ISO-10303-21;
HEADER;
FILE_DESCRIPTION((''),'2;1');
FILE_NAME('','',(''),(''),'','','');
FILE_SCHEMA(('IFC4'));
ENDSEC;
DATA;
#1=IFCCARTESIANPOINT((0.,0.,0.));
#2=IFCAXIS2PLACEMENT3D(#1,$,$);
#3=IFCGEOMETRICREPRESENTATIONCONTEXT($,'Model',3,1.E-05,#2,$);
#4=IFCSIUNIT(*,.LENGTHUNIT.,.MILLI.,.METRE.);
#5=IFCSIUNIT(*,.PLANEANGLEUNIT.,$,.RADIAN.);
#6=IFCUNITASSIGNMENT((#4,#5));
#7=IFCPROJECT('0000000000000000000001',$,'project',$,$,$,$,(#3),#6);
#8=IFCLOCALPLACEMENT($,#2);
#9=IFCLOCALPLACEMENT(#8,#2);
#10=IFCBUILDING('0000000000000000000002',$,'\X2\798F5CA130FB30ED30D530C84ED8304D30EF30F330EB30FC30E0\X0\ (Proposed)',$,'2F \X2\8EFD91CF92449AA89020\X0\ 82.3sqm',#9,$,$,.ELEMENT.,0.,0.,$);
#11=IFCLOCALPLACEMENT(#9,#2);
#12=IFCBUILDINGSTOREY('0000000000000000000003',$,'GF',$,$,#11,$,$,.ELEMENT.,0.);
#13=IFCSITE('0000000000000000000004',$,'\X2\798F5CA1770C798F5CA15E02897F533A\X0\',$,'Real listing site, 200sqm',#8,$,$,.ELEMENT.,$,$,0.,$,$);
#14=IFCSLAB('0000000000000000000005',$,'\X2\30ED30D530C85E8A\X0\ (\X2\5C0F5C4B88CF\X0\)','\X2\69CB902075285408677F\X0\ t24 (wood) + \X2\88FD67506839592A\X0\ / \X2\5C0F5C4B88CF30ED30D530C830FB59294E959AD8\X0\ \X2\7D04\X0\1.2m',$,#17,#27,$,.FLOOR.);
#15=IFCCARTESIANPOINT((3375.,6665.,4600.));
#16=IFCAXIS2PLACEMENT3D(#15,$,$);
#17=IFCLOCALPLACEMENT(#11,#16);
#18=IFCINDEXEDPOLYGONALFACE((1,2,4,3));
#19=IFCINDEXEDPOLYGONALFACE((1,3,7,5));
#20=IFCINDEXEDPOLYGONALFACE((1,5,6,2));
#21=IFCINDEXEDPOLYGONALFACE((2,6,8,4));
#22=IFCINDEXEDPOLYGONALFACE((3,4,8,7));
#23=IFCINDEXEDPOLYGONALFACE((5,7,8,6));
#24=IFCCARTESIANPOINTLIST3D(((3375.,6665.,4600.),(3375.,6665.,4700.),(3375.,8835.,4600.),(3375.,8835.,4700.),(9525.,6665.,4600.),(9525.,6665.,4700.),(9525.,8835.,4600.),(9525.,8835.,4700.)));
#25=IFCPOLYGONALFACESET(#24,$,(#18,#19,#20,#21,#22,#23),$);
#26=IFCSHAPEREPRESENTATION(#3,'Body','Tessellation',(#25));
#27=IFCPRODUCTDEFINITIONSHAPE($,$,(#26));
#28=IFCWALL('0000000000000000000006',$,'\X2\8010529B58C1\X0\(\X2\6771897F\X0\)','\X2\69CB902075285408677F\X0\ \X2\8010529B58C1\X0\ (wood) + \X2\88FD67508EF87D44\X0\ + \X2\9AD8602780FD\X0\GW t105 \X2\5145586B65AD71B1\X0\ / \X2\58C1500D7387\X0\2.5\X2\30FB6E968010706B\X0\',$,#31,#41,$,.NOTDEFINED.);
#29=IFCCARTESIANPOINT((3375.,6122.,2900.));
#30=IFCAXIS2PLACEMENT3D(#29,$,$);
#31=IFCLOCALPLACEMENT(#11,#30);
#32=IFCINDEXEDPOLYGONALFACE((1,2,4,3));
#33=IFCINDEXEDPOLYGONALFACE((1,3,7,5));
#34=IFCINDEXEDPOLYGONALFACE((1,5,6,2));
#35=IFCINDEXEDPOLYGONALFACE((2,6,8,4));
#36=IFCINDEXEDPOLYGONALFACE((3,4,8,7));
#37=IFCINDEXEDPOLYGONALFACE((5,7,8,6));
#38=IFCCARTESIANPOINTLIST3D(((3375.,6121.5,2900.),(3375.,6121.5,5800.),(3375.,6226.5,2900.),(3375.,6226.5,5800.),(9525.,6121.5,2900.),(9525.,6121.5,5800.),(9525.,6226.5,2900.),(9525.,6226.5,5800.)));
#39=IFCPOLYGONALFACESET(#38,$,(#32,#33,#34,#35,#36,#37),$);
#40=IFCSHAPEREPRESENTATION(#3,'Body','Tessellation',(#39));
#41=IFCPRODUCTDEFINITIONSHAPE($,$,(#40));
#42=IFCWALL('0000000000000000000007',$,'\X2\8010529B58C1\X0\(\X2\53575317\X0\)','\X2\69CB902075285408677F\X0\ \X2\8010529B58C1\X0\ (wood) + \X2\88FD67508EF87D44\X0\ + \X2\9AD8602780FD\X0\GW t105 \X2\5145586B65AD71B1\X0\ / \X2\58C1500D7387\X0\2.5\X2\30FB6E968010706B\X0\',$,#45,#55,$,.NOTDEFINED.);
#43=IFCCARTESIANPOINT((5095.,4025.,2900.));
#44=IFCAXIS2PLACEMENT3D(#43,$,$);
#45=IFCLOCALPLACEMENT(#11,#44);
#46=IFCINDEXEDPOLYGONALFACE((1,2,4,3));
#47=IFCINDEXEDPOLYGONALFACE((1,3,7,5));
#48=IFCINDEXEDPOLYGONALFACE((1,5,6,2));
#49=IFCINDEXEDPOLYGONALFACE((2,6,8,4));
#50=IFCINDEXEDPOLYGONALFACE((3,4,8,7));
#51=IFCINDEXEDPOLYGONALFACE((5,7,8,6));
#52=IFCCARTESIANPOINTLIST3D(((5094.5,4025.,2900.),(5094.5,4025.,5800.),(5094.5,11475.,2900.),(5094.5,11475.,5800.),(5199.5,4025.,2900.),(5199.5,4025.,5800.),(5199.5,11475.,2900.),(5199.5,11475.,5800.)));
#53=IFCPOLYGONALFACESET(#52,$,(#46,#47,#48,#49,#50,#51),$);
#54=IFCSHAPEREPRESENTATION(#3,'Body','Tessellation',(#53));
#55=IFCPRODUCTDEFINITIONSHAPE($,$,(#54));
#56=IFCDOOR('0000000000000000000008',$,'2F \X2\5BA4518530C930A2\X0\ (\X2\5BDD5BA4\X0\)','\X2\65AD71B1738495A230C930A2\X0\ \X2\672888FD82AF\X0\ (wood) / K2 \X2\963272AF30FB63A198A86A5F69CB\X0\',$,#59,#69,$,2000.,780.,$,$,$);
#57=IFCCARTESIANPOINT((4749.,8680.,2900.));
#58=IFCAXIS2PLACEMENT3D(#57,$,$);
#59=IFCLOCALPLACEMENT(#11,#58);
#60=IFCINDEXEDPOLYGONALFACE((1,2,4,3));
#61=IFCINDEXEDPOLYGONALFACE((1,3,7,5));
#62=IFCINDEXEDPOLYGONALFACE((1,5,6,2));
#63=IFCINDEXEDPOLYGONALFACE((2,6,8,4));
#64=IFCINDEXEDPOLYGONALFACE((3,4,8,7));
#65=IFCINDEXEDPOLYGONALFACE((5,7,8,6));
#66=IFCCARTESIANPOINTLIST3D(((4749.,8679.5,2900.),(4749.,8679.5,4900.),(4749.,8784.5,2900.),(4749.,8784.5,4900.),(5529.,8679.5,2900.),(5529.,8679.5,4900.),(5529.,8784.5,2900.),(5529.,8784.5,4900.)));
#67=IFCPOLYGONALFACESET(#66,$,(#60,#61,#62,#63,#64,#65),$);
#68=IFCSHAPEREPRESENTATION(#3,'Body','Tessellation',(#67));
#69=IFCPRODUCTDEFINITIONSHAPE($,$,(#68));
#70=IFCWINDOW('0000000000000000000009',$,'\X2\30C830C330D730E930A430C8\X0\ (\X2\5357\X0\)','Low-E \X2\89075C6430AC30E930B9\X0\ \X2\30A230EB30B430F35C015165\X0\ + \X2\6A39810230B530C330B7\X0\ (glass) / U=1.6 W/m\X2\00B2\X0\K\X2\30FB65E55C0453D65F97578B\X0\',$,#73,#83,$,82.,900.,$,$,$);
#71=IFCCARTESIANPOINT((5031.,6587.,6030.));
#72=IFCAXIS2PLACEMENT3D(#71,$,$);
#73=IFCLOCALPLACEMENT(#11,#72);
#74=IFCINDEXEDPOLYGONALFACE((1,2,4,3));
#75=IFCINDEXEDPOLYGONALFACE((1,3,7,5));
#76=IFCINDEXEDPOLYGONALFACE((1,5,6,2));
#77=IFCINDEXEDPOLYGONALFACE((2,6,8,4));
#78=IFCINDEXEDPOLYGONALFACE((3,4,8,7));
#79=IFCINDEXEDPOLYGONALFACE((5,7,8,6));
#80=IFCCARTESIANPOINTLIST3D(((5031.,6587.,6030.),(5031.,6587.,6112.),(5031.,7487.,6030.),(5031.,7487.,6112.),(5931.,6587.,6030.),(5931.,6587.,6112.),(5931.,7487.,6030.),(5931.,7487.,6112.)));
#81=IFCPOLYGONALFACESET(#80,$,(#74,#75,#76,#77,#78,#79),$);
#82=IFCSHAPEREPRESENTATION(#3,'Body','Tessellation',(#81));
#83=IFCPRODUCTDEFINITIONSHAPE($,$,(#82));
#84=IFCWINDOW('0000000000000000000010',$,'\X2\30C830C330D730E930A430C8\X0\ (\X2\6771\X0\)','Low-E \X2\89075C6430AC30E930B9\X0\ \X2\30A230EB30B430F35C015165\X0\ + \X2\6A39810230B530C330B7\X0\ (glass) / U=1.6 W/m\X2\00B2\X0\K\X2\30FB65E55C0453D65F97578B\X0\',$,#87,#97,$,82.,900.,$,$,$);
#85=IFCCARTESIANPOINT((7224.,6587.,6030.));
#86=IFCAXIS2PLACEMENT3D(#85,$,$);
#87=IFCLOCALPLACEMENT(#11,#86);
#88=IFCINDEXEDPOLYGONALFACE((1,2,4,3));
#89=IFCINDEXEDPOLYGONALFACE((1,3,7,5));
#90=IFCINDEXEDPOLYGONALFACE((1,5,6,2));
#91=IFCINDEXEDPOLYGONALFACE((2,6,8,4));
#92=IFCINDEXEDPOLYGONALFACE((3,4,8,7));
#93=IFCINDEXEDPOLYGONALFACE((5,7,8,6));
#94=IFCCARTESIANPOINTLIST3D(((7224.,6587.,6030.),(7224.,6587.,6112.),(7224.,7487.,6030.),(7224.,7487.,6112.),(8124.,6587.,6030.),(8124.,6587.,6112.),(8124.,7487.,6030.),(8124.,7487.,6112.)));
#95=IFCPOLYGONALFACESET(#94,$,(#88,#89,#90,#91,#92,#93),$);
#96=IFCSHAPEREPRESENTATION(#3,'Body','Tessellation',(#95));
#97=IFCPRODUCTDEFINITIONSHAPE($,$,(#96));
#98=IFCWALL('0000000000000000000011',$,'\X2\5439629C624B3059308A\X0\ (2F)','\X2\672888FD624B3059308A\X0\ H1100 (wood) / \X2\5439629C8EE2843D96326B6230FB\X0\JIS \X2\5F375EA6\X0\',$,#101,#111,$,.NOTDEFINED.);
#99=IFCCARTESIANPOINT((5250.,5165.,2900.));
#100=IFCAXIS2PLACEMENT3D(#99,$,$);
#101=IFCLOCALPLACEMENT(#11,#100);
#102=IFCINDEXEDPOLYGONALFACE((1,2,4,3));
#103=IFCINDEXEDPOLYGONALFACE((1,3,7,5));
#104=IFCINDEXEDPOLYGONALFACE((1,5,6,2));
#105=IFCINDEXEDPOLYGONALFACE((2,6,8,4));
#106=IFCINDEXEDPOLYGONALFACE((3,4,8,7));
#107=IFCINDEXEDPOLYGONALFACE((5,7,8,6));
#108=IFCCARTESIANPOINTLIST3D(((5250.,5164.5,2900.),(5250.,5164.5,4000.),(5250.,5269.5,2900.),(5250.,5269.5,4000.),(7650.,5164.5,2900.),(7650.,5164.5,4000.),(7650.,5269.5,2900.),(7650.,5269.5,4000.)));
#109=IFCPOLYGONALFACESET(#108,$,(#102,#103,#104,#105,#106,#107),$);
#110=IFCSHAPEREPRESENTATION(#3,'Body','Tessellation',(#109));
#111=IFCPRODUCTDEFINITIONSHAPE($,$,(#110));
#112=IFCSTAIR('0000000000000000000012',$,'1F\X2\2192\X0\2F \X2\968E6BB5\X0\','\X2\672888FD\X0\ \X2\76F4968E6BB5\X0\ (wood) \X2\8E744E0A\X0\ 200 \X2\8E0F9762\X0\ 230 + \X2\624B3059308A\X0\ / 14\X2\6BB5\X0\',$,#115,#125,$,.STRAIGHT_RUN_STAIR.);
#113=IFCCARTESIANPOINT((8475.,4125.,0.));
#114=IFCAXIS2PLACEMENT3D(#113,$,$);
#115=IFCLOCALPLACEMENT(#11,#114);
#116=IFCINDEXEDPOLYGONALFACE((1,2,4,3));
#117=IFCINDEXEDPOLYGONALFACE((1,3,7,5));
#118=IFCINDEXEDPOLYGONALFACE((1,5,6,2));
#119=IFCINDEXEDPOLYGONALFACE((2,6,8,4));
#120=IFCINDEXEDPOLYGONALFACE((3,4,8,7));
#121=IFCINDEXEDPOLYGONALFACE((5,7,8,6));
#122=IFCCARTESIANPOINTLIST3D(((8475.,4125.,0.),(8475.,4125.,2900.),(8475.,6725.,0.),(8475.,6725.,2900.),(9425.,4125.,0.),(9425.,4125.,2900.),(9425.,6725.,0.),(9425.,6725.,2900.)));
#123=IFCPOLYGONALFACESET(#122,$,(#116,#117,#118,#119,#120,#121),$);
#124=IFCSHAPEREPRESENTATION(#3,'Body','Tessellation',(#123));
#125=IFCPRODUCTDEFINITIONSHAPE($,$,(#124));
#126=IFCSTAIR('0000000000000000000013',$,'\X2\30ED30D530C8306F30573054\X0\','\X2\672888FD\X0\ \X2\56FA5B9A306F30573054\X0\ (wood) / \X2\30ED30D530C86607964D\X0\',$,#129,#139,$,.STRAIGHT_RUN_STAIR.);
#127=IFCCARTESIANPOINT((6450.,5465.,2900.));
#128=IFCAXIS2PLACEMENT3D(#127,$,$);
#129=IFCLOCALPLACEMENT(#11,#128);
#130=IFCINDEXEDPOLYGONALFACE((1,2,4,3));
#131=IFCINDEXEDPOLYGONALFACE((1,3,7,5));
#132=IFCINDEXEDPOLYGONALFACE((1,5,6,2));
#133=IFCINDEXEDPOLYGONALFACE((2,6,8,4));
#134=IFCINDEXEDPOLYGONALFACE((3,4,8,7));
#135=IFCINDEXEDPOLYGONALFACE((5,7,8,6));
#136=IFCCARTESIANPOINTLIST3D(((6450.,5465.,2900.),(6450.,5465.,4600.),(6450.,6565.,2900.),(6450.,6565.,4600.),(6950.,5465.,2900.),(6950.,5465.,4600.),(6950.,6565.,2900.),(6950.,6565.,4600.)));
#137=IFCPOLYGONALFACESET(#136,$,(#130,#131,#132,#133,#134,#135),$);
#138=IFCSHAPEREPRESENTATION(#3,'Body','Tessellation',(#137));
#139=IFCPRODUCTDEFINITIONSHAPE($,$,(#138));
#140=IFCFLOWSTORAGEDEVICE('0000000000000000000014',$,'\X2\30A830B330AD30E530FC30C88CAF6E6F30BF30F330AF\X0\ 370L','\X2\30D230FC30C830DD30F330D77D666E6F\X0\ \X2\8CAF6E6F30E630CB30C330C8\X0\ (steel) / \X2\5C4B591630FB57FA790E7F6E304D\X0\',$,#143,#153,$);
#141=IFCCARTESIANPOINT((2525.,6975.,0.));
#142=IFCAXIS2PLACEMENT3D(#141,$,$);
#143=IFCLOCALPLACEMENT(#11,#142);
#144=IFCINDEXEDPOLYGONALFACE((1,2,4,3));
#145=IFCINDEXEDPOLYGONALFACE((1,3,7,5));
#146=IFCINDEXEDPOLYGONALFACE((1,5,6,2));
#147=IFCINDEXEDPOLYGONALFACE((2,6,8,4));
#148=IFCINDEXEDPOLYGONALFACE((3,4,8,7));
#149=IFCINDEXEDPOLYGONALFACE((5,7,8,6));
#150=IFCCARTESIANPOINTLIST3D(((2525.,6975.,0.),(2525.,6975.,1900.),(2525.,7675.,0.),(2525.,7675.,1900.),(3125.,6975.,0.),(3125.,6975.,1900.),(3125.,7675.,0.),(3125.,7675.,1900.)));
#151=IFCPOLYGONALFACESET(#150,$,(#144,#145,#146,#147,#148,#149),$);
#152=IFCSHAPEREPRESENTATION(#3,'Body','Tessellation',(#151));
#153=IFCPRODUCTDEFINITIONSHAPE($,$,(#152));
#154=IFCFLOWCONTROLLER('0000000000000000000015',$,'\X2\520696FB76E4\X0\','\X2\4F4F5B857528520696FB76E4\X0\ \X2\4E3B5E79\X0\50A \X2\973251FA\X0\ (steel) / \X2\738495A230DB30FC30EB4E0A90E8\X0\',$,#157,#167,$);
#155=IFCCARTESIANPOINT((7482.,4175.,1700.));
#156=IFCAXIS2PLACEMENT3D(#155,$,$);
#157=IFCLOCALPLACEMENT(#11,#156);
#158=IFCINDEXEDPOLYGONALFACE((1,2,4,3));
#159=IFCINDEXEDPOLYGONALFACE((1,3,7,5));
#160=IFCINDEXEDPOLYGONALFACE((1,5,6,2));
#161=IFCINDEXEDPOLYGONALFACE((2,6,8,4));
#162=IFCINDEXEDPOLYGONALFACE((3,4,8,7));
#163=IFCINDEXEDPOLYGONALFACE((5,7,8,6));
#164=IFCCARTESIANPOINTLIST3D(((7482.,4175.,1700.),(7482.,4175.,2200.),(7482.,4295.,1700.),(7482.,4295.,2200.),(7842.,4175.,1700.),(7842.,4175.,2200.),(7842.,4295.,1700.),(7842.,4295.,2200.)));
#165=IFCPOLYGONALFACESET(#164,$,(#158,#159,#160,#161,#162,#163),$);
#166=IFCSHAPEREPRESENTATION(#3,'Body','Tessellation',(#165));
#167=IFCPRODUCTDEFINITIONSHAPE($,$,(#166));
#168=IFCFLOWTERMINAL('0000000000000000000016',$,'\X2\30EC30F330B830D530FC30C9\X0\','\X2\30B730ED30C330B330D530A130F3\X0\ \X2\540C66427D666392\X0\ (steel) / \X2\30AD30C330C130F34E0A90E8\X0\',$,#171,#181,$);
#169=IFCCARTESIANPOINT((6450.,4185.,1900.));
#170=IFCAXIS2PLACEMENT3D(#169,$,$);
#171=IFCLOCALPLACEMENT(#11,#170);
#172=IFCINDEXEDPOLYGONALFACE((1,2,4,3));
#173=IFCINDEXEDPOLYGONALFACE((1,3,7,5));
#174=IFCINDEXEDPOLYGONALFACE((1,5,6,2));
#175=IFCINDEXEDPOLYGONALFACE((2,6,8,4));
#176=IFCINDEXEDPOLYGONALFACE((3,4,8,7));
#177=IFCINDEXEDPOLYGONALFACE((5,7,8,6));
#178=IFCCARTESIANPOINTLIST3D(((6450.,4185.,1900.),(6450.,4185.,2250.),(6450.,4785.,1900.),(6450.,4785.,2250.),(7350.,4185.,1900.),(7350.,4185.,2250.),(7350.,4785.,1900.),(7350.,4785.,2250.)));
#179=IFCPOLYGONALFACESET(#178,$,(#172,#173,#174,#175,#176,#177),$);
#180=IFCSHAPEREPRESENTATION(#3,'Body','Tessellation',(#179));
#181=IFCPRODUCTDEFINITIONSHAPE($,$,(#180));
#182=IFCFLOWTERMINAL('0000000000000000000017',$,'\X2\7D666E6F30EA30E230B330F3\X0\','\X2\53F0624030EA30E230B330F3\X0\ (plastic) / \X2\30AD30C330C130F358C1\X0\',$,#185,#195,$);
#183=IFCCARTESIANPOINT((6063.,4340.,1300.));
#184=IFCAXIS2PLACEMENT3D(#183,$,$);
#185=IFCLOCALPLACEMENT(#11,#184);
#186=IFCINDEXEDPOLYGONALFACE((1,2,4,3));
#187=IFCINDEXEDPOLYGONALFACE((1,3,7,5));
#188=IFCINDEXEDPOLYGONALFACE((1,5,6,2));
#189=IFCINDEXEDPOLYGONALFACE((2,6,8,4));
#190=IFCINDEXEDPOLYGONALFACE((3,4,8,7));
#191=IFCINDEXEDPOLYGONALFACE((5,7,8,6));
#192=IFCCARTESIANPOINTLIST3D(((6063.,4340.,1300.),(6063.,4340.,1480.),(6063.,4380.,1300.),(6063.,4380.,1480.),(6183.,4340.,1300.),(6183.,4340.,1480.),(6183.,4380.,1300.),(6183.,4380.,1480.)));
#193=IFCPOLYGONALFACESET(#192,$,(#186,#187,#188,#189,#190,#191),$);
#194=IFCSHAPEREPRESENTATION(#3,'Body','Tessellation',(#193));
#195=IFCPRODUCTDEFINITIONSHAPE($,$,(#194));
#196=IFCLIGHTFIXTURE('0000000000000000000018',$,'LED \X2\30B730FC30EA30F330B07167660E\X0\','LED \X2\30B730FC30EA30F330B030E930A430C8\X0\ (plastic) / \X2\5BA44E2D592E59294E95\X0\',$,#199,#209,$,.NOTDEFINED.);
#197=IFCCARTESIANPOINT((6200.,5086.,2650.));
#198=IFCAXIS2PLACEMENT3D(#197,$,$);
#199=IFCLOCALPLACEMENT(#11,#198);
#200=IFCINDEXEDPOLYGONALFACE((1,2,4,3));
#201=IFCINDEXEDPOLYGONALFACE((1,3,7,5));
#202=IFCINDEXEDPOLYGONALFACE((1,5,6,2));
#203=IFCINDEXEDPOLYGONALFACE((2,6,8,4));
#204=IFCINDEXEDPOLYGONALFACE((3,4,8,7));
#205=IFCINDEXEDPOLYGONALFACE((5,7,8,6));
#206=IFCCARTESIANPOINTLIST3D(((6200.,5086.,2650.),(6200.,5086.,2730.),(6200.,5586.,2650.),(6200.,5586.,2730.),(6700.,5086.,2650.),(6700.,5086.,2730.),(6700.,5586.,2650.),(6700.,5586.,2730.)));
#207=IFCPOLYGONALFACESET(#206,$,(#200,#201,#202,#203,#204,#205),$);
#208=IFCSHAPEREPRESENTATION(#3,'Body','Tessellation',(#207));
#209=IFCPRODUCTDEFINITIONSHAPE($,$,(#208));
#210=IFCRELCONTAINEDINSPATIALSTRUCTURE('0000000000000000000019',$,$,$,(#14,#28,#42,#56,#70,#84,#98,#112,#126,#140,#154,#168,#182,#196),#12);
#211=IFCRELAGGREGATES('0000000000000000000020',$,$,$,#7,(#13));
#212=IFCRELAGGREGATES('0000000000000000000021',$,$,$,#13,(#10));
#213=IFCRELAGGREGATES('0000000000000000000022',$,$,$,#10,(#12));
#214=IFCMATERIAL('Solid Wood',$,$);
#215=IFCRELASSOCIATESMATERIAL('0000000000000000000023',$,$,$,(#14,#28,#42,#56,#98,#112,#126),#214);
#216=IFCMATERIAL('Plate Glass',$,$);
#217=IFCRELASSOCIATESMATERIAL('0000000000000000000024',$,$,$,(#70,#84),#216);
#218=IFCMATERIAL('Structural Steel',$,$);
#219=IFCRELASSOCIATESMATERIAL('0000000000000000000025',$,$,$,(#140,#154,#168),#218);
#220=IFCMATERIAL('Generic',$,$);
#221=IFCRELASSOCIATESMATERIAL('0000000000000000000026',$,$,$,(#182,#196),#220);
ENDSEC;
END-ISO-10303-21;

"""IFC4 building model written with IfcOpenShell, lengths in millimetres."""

from ifc_helpers import new_model, si_unit, frame, frame_2d, origin, place, context, project, spatial, rectangle, extrude, material, element, fill, save


model = new_model("IFC4")

# Units and contexts
model_context = context("Model", 3, precision=1e-05, world=origin())
ifc_project = project(units=[si_unit("LENGTHUNIT", "METRE", prefix="MILLI"), si_unit("PLANEANGLEUNIT", "RADIAN")], contexts=[model_context])

# Site, building, storey
site_placement = place(None, origin())
site = spatial("IfcSite", under=ifc_project, at=site_placement, Name="福岡県福岡市西区", ObjectType="Real listing site, 200sqm", CompositionType="ELEMENT", RefElevation=0.0)
building_placement = place(site_placement, origin())
building = spatial("IfcBuilding", under=site, at=building_placement, Name="福岡・ロフト付きワンルーム (Proposed)", ObjectType="2F 軽量鉄骨造 82.3sqm", CompositionType="ELEMENT", ElevationOfRefHeight=0.0, ElevationOfTerrain=0.0)
storey_placement = place(building_placement, origin())
storey = spatial("IfcBuildingStorey", under=building, at=storey_placement, Name="GF", CompositionType="ELEMENT", Elevation=0.0)

# Shared definitions
ifc_material_1 = material(Name="Solid Wood")

# Slab
slab_placement = place(storey_placement, frame((3375.0, 6665.0, 4600.0)))
element("IfcSlab", 1, at=slab_placement, inside=storey, material=ifc_material_1, Name="ロフト床 (小屋裏)", Description="構造用合板 t24 (wood) + 製材根太 / 小屋裏ロフト・天井高 約1.2m", PredefinedType="FLOOR", context=model_context, shape_type="SweptSolid", body=[
    extrude(rectangle(XDim=6150.0, YDim=2170.0, at=frame_2d((3075.0, 1085.0))), frame((3375.0, 6665.0, 4600.0)), (0.0, 0.0, 1.0), 100.0),
])

# Wall
wall_1_placement = place(storey_placement, frame((3375.0, 6122.0, 2900.0)))
element("IfcWall", 2, at=wall_1_placement, inside=storey, material=ifc_material_1, Name="耐力壁(東西)", Description="構造用合板 耐力壁 (wood) + 製材軸組 + 高性能GW t105 充填断熱 / 壁倍率2.5・準耐火", PredefinedType="NOTDEFINED", context=model_context, shape_type="SweptSolid", body=[
    extrude(rectangle(XDim=6150.0, YDim=105.0, at=frame_2d((3075.0, 52.0))), frame((3375.0, 6122.0, 2900.0)), (0.0, 0.0, 1.0), 2900.0),
])

# Wall, opening, door
wall_2_placement = place(storey_placement, frame((5095.0, 4025.0, 2900.0)))
wall_2 = element("IfcWall", 3, at=wall_2_placement, inside=storey, material=ifc_material_1, Name="耐力壁(南北)", Description="構造用合板 耐力壁 (wood) + 製材軸組 + 高性能GW t105 充填断熱 / 壁倍率2.5・準耐火", PredefinedType="NOTDEFINED", context=model_context, shape_type="SweptSolid", body=[
    extrude(rectangle(XDim=105.0, YDim=7450.0, at=frame_2d((52.0, 3725.0))), frame((5095.0, 4025.0, 2900.0)), (0.0, 0.0, 1.0), 2900.0),
])
opening_placement = place(storey_placement, frame((4749.0, 8680.0, 2900.0)))
opening = element("IfcOpeningElement", 4, at=opening_placement, cuts=wall_2, PredefinedType="NOTDEFINED", context=model_context, shape_type="SweptSolid", body=[
    extrude(rectangle(XDim=780.0, YDim=105.0, at=frame_2d((390.0, 52.0))), frame((4749.0, 8680.0, 2900.0)), (0.0, 0.0, 1.0), 2000.0),
])
door_placement = place(storey_placement, frame((4749.0, 8680.0, 2900.0)))
door = element("IfcDoor", 5, at=door_placement, inside=storey, material=ifc_material_1, Name="2F 室内ドア (寝室)", Description="断熱玄関ドア 木製芯 (wood) / K2 防犯・採風機構", OverallHeight=2000.0, OverallWidth=780.0, context=model_context, shape_type="SweptSolid", body=[
    extrude(rectangle(XDim=780.0, YDim=105.0, at=frame_2d((390.0, 52.0))), frame((4749.0, 8680.0, 2900.0)), (0.0, 0.0, 1.0), 2000.0),
])
fill(opening, door)

# Windows
ifc_material_2 = material(Name="Plate Glass")
window_1_placement = place(storey_placement, frame((5031.0, 6587.0, 6030.0)))
element("IfcWindow", 6, at=window_1_placement, inside=storey, material=ifc_material_2, Name="トップライト (南)", Description="Low-E 複層ガラス アルゴン封入 + 樹脂サッシ (glass) / U=1.6 W/m²K・日射取得型", OverallHeight=82.0, OverallWidth=900.0, context=model_context, shape_type="SweptSolid", body=[
    extrude(rectangle(XDim=900.0, YDim=900.0, at=frame_2d((450.0, 450.0))), frame((5031.0, 6587.0, 6030.0)), (0.0, 0.0, 1.0), 82.0),
])
window_2_placement = place(storey_placement, frame((7224.0, 6587.0, 6030.0)))
element("IfcWindow", 7, at=window_2_placement, inside=storey, material=ifc_material_2, Name="トップライト (東)", Description="Low-E 複層ガラス アルゴン封入 + 樹脂サッシ (glass) / U=1.6 W/m²K・日射取得型", OverallHeight=82.0, OverallWidth=900.0, context=model_context, shape_type="SweptSolid", body=[
    extrude(rectangle(XDim=900.0, YDim=900.0, at=frame_2d((450.0, 450.0))), frame((7224.0, 6587.0, 6030.0)), (0.0, 0.0, 1.0), 82.0),
])

# Wall
wall_3_placement = place(storey_placement, frame((5250.0, 5165.0, 2900.0)))
element("IfcWall", 8, at=wall_3_placement, inside=storey, material=ifc_material_1, Name="吹抜手すり (2F)", Description="木製手すり H1100 (wood) / 吹抜転落防止・JIS 強度", PredefinedType="NOTDEFINED", context=model_context, shape_type="SweptSolid", body=[
    extrude(rectangle(XDim=2400.0, YDim=105.0, at=frame_2d((1200.0, 52.0))), frame((5250.0, 5165.0, 2900.0)), (0.0, 0.0, 1.0), 1100.0),
])

# Stairs
stair_1_placement = place(storey_placement, frame((8475.0, 4125.0, 0.0)))
element("IfcStair", 9, at=stair_1_placement, inside=storey, material=ifc_material_1, Name="1F→2F 階段", Description="木製 直階段 (wood) 蹴上 200 踏面 230 + 手すり / 14段", PredefinedType="STRAIGHT_RUN_STAIR", context=model_context, shape_type="SweptSolid", body=[
    extrude(rectangle(XDim=950.0, YDim=2600.0, at=frame_2d((475.0, 1300.0))), frame((8475.0, 4125.0, 0.0)), (0.0, 0.0, 1.0), 2900.0),
])
stair_2_placement = place(storey_placement, frame((6450.0, 5465.0, 2900.0)))
element("IfcStair", 10, at=stair_2_placement, inside=storey, material=ifc_material_1, Name="ロフトはしご", Description="木製 固定はしご (wood) / ロフト昇降", PredefinedType="STRAIGHT_RUN_STAIR", context=model_context, shape_type="SweptSolid", body=[
    extrude(rectangle(XDim=500.0, YDim=1100.0, at=frame_2d((250.0, 550.0))), frame((6450.0, 5465.0, 2900.0)), (0.0, 0.0, 1.0), 1700.0),
])

# Flow storage device
ifc_material_3 = material(Name="Structural Steel")
flow_storage_device_placement = place(storey_placement, frame((2525.0, 6975.0, 0.0)))
element("IfcFlowStorageDevice", 11, at=flow_storage_device_placement, inside=storey, material=ifc_material_3, Name="エコキュート貯湯タンク 370L", Description="ヒートポンプ給湯 貯湯ユニット (steel) / 屋外・基礎置き", context=model_context, shape_type="SweptSolid", body=[
    extrude(rectangle(XDim=600.0, YDim=700.0, at=frame_2d((300.0, 350.0))), frame((2525.0, 6975.0, 0.0)), (0.0, 0.0, 1.0), 1900.0),
])

# Flow controller
flow_controller_placement = place(storey_placement, frame((7482.0, 4175.0, 1700.0)))
element("IfcFlowController", 12, at=flow_controller_placement, inside=storey, material=ifc_material_3, Name="分電盤", Description="住宅用分電盤 主幹50A 露出 (steel) / 玄関ホール上部", context=model_context, shape_type="SweptSolid", body=[
    extrude(rectangle(XDim=360.0, YDim=120.0, at=frame_2d((180.0, 60.0))), frame((7482.0, 4175.0, 1700.0)), (0.0, 0.0, 1.0), 500.0),
])

# Flow terminals
flow_terminal_1_placement = place(storey_placement, frame((6450.0, 4185.0, 1900.0)))
element("IfcFlowTerminal", 13, at=flow_terminal_1_placement, inside=storey, material=ifc_material_3, Name="レンジフード", Description="シロッコファン 同時給排 (steel) / キッチン上部", context=model_context, shape_type="SweptSolid", body=[
    extrude(rectangle(XDim=900.0, YDim=600.0, at=frame_2d((450.0, 300.0))), frame((6450.0, 4185.0, 1900.0)), (0.0, 0.0, 1.0), 350.0),
])
ifc_material_4 = material(Name="Generic")
flow_terminal_2_placement = place(storey_placement, frame((6063.0, 4340.0, 1300.0)))
element("IfcFlowTerminal", 14, at=flow_terminal_2_placement, inside=storey, material=ifc_material_4, Name="給湯リモコン", Description="台所リモコン (plastic) / キッチン壁", context=model_context, shape_type="SweptSolid", body=[
    extrude(rectangle(XDim=120.0, YDim=40.0, at=frame_2d((60.0, 20.0))), frame((6063.0, 4340.0, 1300.0)), (0.0, 0.0, 1.0), 180.0),
])

# Light fixture
light_fixture_1_placement = place(storey_placement, frame((6200.0, 5086.0, 2650.0)))
element("IfcLightFixture", 15, at=light_fixture_1_placement, inside=storey, material=ifc_material_4, Name="LED シーリング照明", Description="LED シーリングライト (plastic) / 室中央天井", PredefinedType="NOTDEFINED", context=model_context, shape_type="SweptSolid", body=[
    extrude(rectangle(XDim=500.0, YDim=500.0, at=frame_2d((250.0, 250.0))), frame((6200.0, 5086.0, 2650.0)), (0.0, 0.0, 1.0), 80.0),
])

save(model, "model.ifc")
